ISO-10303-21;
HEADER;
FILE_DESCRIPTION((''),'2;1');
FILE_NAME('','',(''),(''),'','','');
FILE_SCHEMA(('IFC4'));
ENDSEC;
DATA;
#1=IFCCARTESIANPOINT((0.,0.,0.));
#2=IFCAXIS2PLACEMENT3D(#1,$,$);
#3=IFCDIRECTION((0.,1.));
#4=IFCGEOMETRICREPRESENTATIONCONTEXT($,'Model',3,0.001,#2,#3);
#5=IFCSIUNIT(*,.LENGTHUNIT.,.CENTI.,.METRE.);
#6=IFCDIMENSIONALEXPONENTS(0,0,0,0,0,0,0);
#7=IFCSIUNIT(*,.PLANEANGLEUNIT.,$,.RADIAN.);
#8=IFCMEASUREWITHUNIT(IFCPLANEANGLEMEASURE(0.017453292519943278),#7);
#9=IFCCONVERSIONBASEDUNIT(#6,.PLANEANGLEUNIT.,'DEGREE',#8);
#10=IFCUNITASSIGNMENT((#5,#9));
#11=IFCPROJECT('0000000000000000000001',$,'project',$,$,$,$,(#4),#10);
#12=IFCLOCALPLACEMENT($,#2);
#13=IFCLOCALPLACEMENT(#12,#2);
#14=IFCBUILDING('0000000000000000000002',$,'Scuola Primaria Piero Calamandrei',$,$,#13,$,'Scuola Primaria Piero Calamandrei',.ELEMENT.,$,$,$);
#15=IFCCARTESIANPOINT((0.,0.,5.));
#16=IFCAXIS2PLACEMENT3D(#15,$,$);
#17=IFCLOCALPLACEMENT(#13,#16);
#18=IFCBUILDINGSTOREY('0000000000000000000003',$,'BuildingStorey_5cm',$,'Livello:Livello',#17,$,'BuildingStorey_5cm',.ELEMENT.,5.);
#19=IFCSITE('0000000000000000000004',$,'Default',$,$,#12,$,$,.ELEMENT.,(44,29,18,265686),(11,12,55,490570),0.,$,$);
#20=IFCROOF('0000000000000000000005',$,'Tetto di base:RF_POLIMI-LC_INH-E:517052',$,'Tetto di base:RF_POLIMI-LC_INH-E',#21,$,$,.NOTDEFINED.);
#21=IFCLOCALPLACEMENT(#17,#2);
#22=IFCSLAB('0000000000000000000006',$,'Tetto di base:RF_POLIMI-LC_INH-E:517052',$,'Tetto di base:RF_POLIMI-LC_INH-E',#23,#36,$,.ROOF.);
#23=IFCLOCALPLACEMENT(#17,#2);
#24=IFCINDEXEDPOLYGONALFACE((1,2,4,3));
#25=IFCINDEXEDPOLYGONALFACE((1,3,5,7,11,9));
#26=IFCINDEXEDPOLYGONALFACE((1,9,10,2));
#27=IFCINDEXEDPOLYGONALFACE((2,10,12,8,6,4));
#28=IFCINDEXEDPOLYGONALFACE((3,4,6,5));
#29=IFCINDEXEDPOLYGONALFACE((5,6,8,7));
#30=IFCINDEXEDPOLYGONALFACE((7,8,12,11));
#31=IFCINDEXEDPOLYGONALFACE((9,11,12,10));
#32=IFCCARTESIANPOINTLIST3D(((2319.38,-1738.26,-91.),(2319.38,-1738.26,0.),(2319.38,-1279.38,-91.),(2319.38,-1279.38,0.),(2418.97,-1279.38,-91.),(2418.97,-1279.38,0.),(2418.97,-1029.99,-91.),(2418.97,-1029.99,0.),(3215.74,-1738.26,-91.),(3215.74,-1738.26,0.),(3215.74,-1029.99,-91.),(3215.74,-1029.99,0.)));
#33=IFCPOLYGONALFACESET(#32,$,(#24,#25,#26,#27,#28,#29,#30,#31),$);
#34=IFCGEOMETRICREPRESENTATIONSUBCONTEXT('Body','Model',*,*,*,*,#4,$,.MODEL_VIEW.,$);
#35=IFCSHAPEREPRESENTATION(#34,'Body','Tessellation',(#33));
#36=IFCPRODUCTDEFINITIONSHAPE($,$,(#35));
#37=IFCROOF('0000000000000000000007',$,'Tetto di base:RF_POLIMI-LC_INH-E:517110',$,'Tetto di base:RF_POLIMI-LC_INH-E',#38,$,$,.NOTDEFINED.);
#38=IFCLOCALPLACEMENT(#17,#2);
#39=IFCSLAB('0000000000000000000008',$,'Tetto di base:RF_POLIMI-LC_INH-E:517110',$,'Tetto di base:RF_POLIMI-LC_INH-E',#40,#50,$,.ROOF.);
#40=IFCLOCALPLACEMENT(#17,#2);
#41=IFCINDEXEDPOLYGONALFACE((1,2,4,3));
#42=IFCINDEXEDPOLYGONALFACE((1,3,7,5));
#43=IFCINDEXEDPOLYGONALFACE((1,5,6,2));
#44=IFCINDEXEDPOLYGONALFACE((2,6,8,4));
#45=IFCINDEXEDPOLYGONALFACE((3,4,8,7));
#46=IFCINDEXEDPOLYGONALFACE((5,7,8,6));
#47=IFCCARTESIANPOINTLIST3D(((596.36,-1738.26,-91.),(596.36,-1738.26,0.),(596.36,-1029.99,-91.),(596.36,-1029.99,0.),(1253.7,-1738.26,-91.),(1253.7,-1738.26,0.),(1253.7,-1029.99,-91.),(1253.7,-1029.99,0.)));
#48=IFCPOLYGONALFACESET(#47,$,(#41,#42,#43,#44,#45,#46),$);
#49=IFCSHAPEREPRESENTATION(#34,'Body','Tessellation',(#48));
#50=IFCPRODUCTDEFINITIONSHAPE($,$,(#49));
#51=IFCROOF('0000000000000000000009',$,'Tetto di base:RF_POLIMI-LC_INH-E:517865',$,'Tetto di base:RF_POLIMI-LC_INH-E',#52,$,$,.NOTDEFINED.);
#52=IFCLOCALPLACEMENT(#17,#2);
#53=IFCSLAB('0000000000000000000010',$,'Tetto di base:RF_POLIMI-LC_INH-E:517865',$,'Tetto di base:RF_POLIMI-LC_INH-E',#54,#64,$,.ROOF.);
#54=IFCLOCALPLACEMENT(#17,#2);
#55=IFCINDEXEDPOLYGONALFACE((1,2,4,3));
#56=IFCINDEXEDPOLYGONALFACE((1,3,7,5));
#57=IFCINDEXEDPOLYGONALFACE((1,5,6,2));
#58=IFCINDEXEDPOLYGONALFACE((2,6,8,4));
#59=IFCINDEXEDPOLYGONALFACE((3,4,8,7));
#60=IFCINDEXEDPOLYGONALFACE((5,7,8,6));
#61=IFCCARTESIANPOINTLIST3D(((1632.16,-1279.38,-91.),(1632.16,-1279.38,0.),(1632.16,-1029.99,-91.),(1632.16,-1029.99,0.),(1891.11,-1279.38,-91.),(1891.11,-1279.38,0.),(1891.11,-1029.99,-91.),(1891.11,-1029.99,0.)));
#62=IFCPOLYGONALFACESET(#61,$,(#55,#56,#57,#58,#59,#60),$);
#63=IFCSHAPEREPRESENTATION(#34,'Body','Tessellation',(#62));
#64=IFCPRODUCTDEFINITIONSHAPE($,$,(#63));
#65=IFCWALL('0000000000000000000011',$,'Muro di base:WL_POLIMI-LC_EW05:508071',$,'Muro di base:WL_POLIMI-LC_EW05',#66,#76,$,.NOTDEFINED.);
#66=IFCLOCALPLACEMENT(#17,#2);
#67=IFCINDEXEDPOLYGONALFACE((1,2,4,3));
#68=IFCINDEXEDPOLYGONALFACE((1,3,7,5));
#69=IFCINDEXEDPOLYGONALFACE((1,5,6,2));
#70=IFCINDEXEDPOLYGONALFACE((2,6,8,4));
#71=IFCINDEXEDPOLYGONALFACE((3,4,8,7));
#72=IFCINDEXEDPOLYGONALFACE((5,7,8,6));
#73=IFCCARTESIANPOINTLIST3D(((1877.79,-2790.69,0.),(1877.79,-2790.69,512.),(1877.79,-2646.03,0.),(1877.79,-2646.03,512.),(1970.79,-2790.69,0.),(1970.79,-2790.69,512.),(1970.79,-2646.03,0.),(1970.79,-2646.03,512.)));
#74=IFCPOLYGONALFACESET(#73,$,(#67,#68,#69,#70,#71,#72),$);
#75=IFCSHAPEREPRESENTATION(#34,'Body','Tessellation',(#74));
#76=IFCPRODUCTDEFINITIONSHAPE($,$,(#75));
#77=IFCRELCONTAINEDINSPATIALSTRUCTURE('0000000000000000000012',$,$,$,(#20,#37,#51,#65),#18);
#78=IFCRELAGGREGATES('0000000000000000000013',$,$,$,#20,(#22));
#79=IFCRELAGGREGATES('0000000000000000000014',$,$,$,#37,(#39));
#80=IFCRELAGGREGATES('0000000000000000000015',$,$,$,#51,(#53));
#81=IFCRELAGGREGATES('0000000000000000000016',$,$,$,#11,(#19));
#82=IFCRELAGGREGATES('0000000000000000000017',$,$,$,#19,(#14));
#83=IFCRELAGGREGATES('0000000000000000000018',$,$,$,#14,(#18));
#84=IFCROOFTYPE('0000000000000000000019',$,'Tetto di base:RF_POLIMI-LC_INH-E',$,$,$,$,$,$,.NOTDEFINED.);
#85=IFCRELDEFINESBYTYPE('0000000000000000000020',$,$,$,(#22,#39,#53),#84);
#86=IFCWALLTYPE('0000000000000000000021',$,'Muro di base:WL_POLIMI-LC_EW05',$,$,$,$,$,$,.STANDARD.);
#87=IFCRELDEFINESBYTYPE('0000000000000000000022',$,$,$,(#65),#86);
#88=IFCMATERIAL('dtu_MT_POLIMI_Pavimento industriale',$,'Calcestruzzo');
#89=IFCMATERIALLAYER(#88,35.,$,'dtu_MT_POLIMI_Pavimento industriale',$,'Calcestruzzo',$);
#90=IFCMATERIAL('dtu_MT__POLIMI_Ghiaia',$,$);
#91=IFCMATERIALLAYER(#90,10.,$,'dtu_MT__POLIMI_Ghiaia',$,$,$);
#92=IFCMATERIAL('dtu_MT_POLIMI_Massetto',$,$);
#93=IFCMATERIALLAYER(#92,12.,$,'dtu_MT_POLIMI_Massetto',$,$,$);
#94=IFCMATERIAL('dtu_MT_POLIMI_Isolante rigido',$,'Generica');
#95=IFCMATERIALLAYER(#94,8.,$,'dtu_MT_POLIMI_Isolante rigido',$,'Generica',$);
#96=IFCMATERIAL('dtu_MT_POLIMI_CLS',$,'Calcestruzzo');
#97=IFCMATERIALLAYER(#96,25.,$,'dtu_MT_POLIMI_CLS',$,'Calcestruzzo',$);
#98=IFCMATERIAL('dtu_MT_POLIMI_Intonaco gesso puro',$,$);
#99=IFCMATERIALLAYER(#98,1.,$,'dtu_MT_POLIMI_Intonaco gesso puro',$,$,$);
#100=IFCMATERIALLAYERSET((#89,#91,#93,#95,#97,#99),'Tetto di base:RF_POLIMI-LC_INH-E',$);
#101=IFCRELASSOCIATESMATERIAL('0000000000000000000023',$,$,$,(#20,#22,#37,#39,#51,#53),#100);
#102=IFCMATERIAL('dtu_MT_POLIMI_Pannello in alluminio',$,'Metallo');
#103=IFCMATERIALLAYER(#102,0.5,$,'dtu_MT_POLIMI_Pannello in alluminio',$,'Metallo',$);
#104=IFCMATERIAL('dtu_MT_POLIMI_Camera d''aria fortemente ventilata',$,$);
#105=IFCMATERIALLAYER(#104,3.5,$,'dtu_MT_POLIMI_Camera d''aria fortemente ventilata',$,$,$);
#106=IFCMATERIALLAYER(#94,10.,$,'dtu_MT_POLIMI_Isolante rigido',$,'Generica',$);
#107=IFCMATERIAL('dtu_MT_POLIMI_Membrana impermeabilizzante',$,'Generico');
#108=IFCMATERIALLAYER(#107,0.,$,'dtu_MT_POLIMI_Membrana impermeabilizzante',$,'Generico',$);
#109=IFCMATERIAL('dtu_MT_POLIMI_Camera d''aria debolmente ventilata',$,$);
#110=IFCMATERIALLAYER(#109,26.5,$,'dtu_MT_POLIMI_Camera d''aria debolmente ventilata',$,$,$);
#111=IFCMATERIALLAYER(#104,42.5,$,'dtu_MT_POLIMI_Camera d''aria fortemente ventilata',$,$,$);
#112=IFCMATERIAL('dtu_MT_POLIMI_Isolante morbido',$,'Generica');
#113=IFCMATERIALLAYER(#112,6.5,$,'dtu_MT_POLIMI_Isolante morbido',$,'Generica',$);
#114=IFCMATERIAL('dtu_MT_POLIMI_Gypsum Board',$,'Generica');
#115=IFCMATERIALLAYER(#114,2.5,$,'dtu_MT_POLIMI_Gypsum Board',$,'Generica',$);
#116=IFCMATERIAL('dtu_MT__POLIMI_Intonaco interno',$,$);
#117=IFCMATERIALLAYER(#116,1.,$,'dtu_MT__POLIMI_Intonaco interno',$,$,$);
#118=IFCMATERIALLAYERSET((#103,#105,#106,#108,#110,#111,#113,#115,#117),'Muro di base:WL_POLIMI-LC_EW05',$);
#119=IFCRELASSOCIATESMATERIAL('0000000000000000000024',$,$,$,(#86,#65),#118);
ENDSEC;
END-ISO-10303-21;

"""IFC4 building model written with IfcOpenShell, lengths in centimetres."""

from ifc_helpers import new_model, entity, si_unit, converted_unit, direction, frame, frame_2d, origin, place, context, subcontext, project, spatial, polyline, rectangle, outline, extrude, material, layer, layer_set, layer_usage, type_object, element, aggregate, save


model = new_model("IFC4")

# Units and contexts
model_context = context("Model", 3, precision=0.001, world=origin(), true_north=direction((0.0, 1.0)))
body_context = subcontext(model_context, "Body", "Model", "MODEL_VIEW")
ifc_project = project(units=[si_unit("LENGTHUNIT", "METRE", prefix="CENTI"), converted_unit("PLANEANGLEUNIT", "DEGREE", entity("IfcPlaneAngleMeasure", 0.017453292519943278), si_unit("PLANEANGLEUNIT", "RADIAN"), dimensions=[0, 0, 0, 0, 0, 0, 0])], contexts=[model_context])

# Site, building, storey
site_placement = place(None, origin())
site = spatial("IfcSite", under=ifc_project, at=site_placement, Name="Default", CompositionType="ELEMENT", RefLatitude=(44, 29, 18, 265686), RefLongitude=(11, 12, 55, 490570), RefElevation=0.0)
building_placement = place(site_placement, origin())
building = spatial("IfcBuilding", under=site, at=building_placement, Name="Scuola Primaria Piero Calamandrei", LongName="Scuola Primaria Piero Calamandrei", CompositionType="ELEMENT")
storey_placement = place(building_placement, frame((0.0, 0.0, 5.0)))
storey = spatial("IfcBuildingStorey", under=building, at=storey_placement, Name="BuildingStorey_5cm", ObjectType="Livello:Livello", LongName="BuildingStorey_5cm", CompositionType="ELEMENT", Elevation=5.0)

# Shared definitions
ifc_material_1 = material(Name="dtu_MT_POLIMI_Isolante rigido", Category="Generica")
ifc_material_2 = material(Name="dtu_MT__POLIMI_Intonaco interno")

# Roofs, slabs
ifc_material_3 = material(Name="dtu_MT_POLIMI_Pavimento industriale", Category="Calcestruzzo")
ifc_layer_1 = layer(ifc_material_3, 35.0, Name="dtu_MT_POLIMI_Pavimento industriale", Category="Calcestruzzo")
ifc_material_4 = material(Name="dtu_MT__POLIMI_Ghiaia")
ifc_layer_2 = layer(ifc_material_4, 10.0, Name="dtu_MT__POLIMI_Ghiaia")
ifc_material_5 = material(Name="dtu_MT_POLIMI_Massetto")
ifc_layer_3 = layer(ifc_material_5, 12.0, Name="dtu_MT_POLIMI_Massetto")
ifc_layer_4 = layer(ifc_material_1, 8.0, Name="dtu_MT_POLIMI_Isolante rigido", Category="Generica")
ifc_material_6 = material(Name="dtu_MT_POLIMI_CLS", Category="Calcestruzzo")
ifc_layer_5 = layer(ifc_material_6, 25.0, Name="dtu_MT_POLIMI_CLS", Category="Calcestruzzo")
ifc_material_7 = material(Name="dtu_MT_POLIMI_Intonaco gesso puro")
ifc_layer_6 = layer(ifc_material_7, 1.0, Name="dtu_MT_POLIMI_Intonaco gesso puro")
ifc_layer_set_1 = layer_set([ifc_layer_1, ifc_layer_2, ifc_layer_3, ifc_layer_4, ifc_layer_5, ifc_layer_6], Name="Tetto di base:RF_POLIMI-LC_INH-E")
roof_1_placement = place(storey_placement, frame((2319.38, -1738.26, -91.0)))
roof_1 = element("IfcRoof", 1, at=roof_1_placement, inside=storey, material=ifc_layer_set_1, Name="Tetto di base:RF_POLIMI-LC_INH-E:517052", ObjectType="Tetto di base:RF_POLIMI-LC_INH-E", PredefinedType="NOTDEFINED")
roof_type = type_object("IfcRoofType", Name="Tetto di base:RF_POLIMI-LC_INH-E", PredefinedType="NOTDEFINED")
slab_1_placement = place(roof_1_placement, origin())
slab_1 = element("IfcSlab", 2, at=slab_1_placement, type_object=roof_type, material=ifc_layer_set_1, Name="Tetto di base:RF_POLIMI-LC_INH-E:517052", ObjectType="Tetto di base:RF_POLIMI-LC_INH-E", PredefinedType="ROOF", context=body_context, shape_type="SweptSolid", body=[
    extrude(outline(polyline([(448.18, 354.13), (-348.59, 354.13), (-348.59, 104.74), (-448.18, 104.74), (-448.18, -354.13), (448.18, -354.13), (448.18, 354.13)])), frame((448.18, 354.13, 0.0)), (0.0, 0.0, 1.0), 91.0),
])
aggregate(roof_1, [slab_1])
roof_2_placement = place(storey_placement, frame((596.36, -1738.26, -91.0)))
roof_2 = element("IfcRoof", 3, at=roof_2_placement, inside=storey, material=ifc_layer_set_1, Name="Tetto di base:RF_POLIMI-LC_INH-E:517110", ObjectType="Tetto di base:RF_POLIMI-LC_INH-E", PredefinedType="NOTDEFINED")
slab_2_placement = place(roof_2_placement, origin())
slab_2 = element("IfcSlab", 4, at=slab_2_placement, type_object=roof_type, material=ifc_layer_set_1, Name="Tetto di base:RF_POLIMI-LC_INH-E:517110", ObjectType="Tetto di base:RF_POLIMI-LC_INH-E", PredefinedType="ROOF", context=body_context, shape_type="SweptSolid", body=[
    extrude(rectangle(XDim=708.26, YDim=657.33, at=frame_2d((0.0, 0.0), x_axis=(0.0, -1.0))), frame((328.67, 354.13, 0.0)), (0.0, 0.0, 1.0), 91.0),
])
aggregate(roof_2, [slab_2])
roof_3_placement = place(storey_placement, frame((1632.16, -1279.38, -91.0)))
roof_3 = element("IfcRoof", 5, at=roof_3_placement, inside=storey, material=ifc_layer_set_1, Name="Tetto di base:RF_POLIMI-LC_INH-E:517865", ObjectType="Tetto di base:RF_POLIMI-LC_INH-E", PredefinedType="NOTDEFINED")
slab_3_placement = place(roof_3_placement, origin())
slab_3 = element("IfcSlab", 6, at=slab_3_placement, type_object=roof_type, material=ifc_layer_set_1, Name="Tetto di base:RF_POLIMI-LC_INH-E:517865", ObjectType="Tetto di base:RF_POLIMI-LC_INH-E", PredefinedType="ROOF", context=body_context, shape_type="SweptSolid", body=[
    extrude(rectangle(XDim=249.39, YDim=258.95, at=frame_2d((0.0, 0.0), x_axis=(0.0, -1.0))), frame((129.48, 124.69, 0.0)), (0.0, 0.0, 1.0), 91.0),
])
aggregate(roof_3, [slab_3])

# Wall
ifc_material_8 = material(Name="dtu_MT_POLIMI_Pannello in alluminio", Category="Metallo")
ifc_layer_7 = layer(ifc_material_8, 0.5, Name="dtu_MT_POLIMI_Pannello in alluminio", Category="Metallo")
ifc_material_9 = material(Name="dtu_MT_POLIMI_Camera d'aria fortemente ventilata")
ifc_layer_8 = layer(ifc_material_9, 3.5, Name="dtu_MT_POLIMI_Camera d'aria fortemente ventilata")
ifc_layer_9 = layer(ifc_material_1, 10.0, Name="dtu_MT_POLIMI_Isolante rigido", Category="Generica")
ifc_material_10 = material(Name="dtu_MT_POLIMI_Membrana impermeabilizzante", Category="Generico")
ifc_layer_10 = layer(ifc_material_10, 0.0, Name="dtu_MT_POLIMI_Membrana impermeabilizzante", Category="Generico")
ifc_material_11 = material(Name="dtu_MT_POLIMI_Camera d'aria debolmente ventilata")
ifc_layer_11 = layer(ifc_material_11, 26.5, Name="dtu_MT_POLIMI_Camera d'aria debolmente ventilata")
ifc_layer_12 = layer(ifc_material_9, 42.5, Name="dtu_MT_POLIMI_Camera d'aria fortemente ventilata")
ifc_material_12 = material(Name="dtu_MT_POLIMI_Isolante morbido", Category="Generica")
ifc_layer_13 = layer(ifc_material_12, 6.5, Name="dtu_MT_POLIMI_Isolante morbido", Category="Generica")
ifc_material_13 = material(Name="dtu_MT_POLIMI_Gypsum Board", Category="Generica")
ifc_layer_14 = layer(ifc_material_13, 2.5, Name="dtu_MT_POLIMI_Gypsum Board", Category="Generica")
ifc_layer_15 = layer(ifc_material_2, 1.0, Name="dtu_MT__POLIMI_Intonaco interno")
ifc_layer_set_2 = layer_set([ifc_layer_7, ifc_layer_8, ifc_layer_9, ifc_layer_10, ifc_layer_11, ifc_layer_12, ifc_layer_13, ifc_layer_14, ifc_layer_15], Name="Muro di base:WL_POLIMI-LC_EW05")
ifc_layer_usage_1 = layer_usage(ifc_layer_set_2, "AXIS2", "NEGATIVE", 46.5)
wall_type = type_object("IfcWallType", Name="Muro di base:WL_POLIMI-LC_EW05", PredefinedType="STANDARD", material=ifc_layer_set_2)
wall_placement = place(storey_placement, frame((1924.29, -2646.03, 0.0), z_axis=(0.0, 0.0, 1.0), x_axis=(0.0, -1.0, 0.0)))
element("IfcWall", 7, at=wall_placement, inside=storey, type_object=wall_type, material=ifc_layer_usage_1, Name="Muro di base:WL_POLIMI-LC_EW05:508071", ObjectType="Muro di base:WL_POLIMI-LC_EW05", PredefinedType="NOTDEFINED", context=body_context, shape_type="SweptSolid", body=[
    extrude(rectangle(XDim=144.66, YDim=93.0, at=frame_2d((72.33, 0.0), x_axis=(-1.0, 0.0))), origin(), (0.0, 0.0, 1.0), 512.0),
])

save(model, "model.ifc")
